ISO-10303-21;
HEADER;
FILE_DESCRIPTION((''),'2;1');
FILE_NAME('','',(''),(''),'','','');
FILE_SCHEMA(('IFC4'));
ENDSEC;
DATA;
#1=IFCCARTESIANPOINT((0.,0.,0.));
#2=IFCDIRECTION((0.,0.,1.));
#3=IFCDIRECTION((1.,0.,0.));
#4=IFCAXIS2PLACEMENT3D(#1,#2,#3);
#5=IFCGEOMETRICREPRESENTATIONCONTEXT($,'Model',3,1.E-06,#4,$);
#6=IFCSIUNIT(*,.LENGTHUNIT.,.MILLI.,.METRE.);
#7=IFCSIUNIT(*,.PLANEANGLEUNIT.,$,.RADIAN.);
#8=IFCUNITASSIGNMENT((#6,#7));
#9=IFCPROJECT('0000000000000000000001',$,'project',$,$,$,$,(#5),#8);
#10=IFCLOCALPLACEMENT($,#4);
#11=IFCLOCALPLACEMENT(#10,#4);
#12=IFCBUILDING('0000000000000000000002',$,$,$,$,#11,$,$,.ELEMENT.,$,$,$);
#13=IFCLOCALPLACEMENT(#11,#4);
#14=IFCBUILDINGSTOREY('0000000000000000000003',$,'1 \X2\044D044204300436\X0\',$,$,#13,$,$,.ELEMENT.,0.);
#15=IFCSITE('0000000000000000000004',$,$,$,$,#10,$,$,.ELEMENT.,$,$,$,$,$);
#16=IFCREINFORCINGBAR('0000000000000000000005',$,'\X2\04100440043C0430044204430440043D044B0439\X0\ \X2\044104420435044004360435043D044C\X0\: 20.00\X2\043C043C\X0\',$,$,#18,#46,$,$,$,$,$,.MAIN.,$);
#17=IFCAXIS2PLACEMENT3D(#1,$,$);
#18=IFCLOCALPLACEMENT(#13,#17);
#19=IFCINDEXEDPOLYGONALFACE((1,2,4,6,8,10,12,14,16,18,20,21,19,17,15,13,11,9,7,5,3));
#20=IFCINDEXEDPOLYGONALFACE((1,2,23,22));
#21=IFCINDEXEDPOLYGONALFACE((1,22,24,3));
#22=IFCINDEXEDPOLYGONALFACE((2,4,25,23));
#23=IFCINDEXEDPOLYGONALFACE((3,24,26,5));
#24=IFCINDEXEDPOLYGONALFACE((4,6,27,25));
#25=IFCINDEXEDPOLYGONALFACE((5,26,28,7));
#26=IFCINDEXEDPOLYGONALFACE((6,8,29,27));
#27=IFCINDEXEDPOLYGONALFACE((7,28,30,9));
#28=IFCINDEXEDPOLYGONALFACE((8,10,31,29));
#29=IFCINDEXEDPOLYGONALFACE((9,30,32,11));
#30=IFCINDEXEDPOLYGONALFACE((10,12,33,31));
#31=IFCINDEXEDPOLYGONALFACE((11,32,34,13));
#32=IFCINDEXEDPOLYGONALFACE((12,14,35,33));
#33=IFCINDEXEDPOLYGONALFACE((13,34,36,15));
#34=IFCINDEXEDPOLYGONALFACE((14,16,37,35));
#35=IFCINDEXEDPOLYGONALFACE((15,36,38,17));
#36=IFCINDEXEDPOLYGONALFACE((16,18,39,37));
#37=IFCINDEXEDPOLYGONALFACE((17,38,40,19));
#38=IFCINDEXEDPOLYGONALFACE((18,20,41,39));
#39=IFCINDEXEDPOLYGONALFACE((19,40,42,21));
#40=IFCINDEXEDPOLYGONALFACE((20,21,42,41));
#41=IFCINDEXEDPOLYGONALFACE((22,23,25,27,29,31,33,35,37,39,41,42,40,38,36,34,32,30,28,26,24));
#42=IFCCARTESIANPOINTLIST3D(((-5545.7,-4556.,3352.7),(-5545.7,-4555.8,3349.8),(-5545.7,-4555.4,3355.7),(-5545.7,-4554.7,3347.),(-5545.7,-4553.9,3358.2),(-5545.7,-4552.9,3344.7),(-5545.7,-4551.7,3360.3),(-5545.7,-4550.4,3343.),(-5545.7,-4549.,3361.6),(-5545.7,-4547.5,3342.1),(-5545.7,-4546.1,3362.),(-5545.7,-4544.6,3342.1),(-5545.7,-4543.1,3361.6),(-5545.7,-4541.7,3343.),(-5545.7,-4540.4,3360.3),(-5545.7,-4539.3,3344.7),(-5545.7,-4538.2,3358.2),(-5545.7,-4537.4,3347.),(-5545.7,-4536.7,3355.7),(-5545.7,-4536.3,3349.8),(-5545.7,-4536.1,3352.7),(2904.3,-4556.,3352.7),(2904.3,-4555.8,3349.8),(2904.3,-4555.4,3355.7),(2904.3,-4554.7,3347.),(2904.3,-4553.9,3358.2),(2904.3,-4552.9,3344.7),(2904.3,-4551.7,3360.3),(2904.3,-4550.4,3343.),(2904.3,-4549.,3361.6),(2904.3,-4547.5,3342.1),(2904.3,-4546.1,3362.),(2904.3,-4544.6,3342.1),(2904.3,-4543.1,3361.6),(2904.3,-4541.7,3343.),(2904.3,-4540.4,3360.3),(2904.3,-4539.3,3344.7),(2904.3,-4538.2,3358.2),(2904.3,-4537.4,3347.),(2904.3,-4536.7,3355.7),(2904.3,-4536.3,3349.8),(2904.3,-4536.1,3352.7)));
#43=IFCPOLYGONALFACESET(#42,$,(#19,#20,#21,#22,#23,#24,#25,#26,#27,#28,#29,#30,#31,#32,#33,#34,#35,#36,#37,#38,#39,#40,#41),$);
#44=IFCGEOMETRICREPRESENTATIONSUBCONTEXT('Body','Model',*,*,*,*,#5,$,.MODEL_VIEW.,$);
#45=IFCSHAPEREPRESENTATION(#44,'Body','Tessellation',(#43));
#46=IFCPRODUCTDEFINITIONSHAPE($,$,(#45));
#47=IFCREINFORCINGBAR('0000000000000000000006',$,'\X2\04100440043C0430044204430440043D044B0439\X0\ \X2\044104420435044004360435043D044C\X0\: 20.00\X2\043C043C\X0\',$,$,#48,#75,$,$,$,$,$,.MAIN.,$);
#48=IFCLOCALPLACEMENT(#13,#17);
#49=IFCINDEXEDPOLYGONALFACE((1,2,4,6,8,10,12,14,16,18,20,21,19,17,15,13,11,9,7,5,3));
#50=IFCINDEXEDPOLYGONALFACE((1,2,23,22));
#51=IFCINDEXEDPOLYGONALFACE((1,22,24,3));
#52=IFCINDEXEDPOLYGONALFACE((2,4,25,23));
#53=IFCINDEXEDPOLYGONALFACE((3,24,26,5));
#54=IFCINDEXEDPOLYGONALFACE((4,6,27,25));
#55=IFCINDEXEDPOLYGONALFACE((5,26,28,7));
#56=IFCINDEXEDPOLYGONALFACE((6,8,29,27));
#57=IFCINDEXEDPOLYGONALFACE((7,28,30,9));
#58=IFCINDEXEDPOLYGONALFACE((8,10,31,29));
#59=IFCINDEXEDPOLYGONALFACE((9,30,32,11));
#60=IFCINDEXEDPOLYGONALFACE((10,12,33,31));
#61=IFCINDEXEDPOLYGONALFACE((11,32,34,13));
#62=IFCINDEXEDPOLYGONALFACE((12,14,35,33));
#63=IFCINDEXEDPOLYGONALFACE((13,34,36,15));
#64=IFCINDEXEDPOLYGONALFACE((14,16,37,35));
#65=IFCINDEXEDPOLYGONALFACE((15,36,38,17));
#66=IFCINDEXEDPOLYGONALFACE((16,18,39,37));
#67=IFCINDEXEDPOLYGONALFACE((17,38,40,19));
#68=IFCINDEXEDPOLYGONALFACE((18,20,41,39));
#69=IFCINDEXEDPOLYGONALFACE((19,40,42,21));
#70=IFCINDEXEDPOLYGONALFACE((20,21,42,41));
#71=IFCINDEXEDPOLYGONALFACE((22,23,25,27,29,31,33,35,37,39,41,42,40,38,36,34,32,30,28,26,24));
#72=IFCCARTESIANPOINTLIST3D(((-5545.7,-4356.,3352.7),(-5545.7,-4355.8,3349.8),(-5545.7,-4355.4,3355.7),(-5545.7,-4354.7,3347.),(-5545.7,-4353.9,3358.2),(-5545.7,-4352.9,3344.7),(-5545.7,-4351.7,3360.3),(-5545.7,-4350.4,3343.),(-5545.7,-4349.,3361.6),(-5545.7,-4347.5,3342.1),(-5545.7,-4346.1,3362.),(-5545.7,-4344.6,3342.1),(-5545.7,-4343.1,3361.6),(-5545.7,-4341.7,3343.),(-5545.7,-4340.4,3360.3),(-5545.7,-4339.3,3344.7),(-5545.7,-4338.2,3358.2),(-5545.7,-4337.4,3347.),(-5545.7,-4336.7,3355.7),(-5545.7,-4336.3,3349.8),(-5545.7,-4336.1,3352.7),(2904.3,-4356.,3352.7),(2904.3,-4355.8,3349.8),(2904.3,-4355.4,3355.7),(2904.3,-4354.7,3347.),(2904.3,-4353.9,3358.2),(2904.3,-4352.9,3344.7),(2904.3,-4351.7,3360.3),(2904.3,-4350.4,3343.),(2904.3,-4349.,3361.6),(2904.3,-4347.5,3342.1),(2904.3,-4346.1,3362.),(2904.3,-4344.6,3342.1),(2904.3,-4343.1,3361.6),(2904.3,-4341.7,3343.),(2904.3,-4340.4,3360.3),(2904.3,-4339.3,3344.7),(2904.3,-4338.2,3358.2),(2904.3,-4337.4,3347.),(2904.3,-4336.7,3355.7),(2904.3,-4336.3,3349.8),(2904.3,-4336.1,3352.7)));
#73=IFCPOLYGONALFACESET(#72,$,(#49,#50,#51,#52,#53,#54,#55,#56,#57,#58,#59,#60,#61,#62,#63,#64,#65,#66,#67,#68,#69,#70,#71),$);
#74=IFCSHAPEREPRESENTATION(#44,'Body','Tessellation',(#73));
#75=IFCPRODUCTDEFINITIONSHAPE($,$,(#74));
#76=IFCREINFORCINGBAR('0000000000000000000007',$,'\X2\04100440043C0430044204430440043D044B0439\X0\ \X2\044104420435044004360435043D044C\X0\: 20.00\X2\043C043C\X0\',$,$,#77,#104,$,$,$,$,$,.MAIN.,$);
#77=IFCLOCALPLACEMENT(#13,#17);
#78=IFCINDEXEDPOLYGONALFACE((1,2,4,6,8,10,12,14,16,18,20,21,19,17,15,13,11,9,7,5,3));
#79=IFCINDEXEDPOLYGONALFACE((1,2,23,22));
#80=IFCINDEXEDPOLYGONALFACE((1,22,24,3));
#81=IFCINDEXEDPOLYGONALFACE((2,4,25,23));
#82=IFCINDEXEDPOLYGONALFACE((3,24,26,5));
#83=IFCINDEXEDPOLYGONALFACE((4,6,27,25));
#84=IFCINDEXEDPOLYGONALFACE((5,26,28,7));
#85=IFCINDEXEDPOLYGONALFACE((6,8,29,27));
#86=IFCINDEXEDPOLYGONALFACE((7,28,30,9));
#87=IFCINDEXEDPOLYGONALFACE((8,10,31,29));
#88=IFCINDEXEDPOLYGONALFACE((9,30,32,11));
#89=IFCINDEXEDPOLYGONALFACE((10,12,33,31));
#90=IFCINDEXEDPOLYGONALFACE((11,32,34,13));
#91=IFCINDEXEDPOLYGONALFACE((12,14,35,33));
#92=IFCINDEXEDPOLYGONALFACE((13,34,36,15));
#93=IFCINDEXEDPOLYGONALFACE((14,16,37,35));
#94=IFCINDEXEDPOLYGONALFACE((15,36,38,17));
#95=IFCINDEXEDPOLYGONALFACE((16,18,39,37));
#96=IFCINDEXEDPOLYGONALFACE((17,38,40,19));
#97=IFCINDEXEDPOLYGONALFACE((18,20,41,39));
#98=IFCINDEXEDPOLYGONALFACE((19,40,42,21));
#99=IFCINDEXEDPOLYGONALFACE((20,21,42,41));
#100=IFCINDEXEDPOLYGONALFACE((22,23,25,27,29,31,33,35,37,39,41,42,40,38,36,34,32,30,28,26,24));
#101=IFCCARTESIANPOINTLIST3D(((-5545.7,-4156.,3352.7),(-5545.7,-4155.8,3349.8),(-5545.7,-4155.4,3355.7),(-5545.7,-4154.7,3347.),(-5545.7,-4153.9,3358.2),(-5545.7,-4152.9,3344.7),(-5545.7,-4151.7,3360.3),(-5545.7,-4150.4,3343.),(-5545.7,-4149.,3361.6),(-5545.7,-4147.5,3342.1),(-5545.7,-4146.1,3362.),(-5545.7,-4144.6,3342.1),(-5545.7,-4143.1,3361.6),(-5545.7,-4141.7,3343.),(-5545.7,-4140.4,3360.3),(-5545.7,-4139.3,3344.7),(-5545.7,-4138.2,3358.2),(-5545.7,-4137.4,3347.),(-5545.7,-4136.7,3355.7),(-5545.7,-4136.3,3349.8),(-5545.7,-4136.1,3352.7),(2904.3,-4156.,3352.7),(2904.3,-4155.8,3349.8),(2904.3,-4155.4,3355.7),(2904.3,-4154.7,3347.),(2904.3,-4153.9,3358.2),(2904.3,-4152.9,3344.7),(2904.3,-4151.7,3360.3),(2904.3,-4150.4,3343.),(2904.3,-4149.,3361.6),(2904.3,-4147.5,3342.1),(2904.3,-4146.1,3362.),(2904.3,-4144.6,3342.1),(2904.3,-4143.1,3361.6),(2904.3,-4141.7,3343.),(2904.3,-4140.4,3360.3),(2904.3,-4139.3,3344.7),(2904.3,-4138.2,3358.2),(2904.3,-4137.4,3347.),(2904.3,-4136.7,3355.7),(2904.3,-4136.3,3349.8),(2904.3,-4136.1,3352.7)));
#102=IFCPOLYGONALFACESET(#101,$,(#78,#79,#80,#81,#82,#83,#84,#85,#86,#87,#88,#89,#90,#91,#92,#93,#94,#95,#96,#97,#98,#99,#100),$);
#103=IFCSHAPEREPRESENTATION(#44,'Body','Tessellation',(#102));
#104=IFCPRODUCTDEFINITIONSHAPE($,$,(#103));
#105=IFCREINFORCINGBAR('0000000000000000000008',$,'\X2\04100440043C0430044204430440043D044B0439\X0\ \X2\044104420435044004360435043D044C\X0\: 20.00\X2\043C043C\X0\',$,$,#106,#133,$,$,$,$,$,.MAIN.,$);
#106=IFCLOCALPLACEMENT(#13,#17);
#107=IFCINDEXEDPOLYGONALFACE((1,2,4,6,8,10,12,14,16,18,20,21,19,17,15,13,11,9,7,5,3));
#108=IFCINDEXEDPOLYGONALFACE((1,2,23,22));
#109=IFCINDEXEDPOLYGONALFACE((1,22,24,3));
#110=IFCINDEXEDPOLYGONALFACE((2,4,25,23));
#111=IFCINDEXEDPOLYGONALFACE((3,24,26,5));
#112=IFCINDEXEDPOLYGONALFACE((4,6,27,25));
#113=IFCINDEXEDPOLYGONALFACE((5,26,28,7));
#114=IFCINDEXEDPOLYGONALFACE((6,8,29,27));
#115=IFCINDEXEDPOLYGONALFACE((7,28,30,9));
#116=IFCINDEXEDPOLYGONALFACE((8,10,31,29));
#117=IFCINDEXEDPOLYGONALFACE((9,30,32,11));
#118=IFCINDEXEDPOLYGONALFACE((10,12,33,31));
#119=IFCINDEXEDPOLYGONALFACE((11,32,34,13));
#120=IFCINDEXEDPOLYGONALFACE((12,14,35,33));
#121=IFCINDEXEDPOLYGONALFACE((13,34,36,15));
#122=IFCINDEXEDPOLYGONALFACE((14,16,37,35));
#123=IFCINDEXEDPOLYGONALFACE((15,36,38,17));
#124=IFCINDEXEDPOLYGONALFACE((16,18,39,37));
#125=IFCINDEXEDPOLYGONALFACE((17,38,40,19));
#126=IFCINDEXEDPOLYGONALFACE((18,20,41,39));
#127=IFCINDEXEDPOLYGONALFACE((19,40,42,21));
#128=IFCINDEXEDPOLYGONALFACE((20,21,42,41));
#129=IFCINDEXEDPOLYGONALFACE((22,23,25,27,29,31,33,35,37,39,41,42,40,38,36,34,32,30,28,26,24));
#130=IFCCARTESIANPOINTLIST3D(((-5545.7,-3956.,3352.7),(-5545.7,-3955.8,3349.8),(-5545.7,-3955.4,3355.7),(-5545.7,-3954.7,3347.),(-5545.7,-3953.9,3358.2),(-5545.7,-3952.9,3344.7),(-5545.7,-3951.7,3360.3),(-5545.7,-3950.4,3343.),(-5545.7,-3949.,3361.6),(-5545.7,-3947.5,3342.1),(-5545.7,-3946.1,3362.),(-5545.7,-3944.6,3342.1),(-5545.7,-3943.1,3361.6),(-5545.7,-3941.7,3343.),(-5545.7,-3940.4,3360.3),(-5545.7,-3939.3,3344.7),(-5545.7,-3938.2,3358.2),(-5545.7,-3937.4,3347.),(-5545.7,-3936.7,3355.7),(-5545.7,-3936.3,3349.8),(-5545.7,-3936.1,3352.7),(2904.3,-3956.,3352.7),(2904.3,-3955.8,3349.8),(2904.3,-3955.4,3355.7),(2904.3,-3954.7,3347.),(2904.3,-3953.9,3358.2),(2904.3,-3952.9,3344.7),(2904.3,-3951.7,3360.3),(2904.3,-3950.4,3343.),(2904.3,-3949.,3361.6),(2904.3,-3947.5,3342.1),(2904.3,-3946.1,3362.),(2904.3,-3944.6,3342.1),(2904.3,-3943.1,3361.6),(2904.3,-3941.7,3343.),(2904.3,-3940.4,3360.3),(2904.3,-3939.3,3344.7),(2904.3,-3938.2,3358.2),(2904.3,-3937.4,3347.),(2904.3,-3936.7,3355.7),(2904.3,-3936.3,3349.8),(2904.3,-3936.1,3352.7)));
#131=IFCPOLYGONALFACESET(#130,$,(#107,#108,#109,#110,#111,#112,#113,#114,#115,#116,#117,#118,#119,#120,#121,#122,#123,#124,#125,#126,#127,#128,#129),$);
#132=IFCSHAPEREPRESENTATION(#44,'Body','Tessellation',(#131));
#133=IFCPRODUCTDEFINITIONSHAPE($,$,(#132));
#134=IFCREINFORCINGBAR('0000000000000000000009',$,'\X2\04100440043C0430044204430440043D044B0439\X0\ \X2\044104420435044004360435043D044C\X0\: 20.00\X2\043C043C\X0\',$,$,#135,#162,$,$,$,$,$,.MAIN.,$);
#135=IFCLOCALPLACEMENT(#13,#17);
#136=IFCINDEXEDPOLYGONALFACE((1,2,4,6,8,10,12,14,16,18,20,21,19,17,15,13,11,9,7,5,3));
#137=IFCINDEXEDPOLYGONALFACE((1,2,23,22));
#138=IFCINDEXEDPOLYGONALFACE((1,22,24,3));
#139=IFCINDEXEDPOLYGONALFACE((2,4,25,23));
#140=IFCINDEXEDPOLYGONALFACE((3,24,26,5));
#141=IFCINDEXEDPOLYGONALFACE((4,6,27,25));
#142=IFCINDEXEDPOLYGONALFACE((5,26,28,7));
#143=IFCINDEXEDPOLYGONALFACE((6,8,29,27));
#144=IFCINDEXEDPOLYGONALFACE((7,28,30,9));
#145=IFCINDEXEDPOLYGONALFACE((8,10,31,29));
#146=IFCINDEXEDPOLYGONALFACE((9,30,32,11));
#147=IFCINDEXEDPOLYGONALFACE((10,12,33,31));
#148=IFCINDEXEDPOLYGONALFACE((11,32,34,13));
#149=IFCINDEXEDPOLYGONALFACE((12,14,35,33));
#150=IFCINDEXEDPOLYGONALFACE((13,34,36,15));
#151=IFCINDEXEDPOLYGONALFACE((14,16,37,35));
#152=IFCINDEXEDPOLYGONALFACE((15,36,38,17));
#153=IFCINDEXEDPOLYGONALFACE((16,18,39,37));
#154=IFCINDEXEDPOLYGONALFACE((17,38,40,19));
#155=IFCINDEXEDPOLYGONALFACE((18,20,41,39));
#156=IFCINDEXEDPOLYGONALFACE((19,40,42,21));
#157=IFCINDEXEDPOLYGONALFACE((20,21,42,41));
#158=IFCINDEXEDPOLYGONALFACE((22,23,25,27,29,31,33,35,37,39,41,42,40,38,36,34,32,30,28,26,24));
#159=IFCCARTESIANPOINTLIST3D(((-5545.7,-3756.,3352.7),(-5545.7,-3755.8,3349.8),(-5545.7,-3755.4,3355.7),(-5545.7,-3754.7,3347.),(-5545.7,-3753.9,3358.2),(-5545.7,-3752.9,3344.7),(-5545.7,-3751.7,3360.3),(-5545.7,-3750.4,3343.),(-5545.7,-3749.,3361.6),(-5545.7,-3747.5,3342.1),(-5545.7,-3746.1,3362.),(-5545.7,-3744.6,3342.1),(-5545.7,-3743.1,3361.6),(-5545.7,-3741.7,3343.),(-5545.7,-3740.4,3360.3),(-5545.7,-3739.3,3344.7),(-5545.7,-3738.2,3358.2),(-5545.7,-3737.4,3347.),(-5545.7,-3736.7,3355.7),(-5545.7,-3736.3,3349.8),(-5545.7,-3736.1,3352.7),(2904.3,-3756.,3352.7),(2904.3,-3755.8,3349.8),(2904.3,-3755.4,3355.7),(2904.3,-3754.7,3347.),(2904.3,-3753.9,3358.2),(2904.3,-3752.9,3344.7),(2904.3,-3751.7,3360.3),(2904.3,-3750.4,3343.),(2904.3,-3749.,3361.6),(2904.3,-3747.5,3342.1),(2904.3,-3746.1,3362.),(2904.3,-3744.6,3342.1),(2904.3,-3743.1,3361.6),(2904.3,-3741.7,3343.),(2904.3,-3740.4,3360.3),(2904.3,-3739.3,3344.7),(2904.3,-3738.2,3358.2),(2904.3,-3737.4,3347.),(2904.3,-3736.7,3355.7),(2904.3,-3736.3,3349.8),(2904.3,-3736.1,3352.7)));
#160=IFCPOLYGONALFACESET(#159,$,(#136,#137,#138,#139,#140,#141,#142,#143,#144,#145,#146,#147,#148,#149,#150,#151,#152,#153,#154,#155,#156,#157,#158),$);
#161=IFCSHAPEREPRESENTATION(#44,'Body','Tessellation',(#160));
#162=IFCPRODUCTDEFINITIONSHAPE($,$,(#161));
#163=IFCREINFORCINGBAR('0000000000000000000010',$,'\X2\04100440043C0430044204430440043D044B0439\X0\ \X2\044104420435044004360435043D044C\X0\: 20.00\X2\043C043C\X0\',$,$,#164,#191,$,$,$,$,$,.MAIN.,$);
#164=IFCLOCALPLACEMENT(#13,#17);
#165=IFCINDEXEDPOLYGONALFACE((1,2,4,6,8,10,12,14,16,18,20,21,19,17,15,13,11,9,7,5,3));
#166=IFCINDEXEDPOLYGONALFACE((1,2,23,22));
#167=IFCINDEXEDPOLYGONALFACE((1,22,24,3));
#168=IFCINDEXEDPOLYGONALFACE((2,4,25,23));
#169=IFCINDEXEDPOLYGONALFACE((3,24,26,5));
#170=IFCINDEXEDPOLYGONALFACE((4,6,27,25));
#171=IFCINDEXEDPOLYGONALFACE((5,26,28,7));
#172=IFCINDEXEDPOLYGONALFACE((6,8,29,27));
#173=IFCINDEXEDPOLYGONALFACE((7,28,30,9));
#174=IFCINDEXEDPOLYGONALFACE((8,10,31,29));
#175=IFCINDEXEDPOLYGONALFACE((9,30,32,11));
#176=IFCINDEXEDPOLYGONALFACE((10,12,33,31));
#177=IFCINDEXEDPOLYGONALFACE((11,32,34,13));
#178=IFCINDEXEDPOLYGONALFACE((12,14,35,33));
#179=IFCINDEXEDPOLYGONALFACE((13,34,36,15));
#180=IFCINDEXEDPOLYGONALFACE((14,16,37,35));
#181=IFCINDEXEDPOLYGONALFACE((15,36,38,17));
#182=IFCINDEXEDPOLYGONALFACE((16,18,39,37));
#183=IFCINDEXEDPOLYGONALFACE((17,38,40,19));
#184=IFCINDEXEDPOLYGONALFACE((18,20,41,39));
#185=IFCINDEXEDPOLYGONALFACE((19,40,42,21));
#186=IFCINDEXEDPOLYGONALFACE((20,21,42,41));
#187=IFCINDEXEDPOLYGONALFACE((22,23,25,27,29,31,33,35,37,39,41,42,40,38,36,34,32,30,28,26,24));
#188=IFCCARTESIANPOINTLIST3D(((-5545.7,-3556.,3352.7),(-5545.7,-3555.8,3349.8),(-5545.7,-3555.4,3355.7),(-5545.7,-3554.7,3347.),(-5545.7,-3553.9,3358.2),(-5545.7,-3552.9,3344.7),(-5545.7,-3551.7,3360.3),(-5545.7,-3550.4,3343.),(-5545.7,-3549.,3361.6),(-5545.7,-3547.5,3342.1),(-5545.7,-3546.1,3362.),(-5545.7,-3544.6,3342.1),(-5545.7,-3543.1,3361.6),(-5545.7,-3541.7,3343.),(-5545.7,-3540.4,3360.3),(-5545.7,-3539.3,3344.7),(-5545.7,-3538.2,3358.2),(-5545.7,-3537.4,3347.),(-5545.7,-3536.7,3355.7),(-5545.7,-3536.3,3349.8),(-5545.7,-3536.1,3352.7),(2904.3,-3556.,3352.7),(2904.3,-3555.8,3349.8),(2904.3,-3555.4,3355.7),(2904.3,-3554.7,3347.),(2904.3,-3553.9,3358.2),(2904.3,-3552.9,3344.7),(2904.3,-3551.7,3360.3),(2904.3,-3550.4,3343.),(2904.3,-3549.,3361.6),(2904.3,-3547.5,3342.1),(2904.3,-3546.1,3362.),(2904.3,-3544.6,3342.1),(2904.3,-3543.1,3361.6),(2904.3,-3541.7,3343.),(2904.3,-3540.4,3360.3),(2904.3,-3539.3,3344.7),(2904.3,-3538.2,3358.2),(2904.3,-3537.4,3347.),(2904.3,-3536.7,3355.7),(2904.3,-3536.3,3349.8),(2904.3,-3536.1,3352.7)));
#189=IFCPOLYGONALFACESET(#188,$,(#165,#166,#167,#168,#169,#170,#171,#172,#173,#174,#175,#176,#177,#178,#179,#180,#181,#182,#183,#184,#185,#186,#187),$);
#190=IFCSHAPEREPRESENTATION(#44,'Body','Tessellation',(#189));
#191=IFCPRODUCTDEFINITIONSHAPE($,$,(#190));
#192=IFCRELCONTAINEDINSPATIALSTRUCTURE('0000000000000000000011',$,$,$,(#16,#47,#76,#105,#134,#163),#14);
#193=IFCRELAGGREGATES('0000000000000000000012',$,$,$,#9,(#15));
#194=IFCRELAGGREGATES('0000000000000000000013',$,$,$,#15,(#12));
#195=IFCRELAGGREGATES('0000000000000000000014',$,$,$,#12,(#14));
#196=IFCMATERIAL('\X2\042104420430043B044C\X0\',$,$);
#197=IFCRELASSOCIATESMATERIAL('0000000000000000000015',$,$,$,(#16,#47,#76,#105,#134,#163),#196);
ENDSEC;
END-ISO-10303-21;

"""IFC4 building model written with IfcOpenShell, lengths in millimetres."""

from ifc_helpers import new_model, entity, si_unit, origin_with_axes, place, context, subcontext, project, spatial, source, transform, mapped, material, element, save


model = new_model("IFC4")

# Units and contexts
model_context = context("Model", 3, precision=1e-06, world=origin_with_axes())
body_context = subcontext(model_context, "Body", "Model", "MODEL_VIEW")
ifc_project = project(units=[si_unit("LENGTHUNIT", "METRE", prefix="MILLI"), si_unit("PLANEANGLEUNIT", "RADIAN")], contexts=[model_context])

# Site, building, storey
site_placement = place(None, origin_with_axes())
site = spatial("IfcSite", under=ifc_project, at=site_placement, CompositionType="ELEMENT")
building_placement = place(site_placement, origin_with_axes())
building = spatial("IfcBuilding", under=site, at=building_placement, CompositionType="ELEMENT")
storey_placement = place(building_placement, origin_with_axes())
storey = spatial("IfcBuildingStorey", under=building, at=storey_placement, Name="1 этаж", CompositionType="ELEMENT", Elevation=0.0)

# Shared definitions
ifc_material_1 = material(Name="Сталь")

# Reinforcing bars
shared_shape_1 = source(origin_with_axes(), body_context, "Body", "AdvancedSweptSolid", [
    entity("IfcSweptDiskSolid", entity("IfcIndexedPolyCurve", entity("IfcCartesianPointList3D", [[0.0, 0.0, 0.0], [8450.0, 0.0, 0.0]]), [entity("IfcLineIndex", [1, 2])]), 10.0),
])
reinforcing_bar_1_placement = place(storey_placement, origin_with_axes())
element("IfcReinforcingBar", 1, at=reinforcing_bar_1_placement, inside=storey, material=ifc_material_1, Name="Арматурный стержень: 20.00мм", PredefinedType="MAIN", context=body_context, shape_type="MappedRepresentation", body=[
    mapped(shared_shape_1, transform((-5545.7, -4546.1, 3352.0), x_axis=(1.0, 0.0, 0.0), y_axis=(0.0, 1.0, 0.0), z_axis=(0.0, 0.0, 1.0), scale=1.0)),
])
reinforcing_bar_2_placement = place(storey_placement, origin_with_axes())
element("IfcReinforcingBar", 2, at=reinforcing_bar_2_placement, inside=storey, material=ifc_material_1, Name="Арматурный стержень: 20.00мм", PredefinedType="MAIN", context=body_context, shape_type="MappedRepresentation", body=[
    mapped(shared_shape_1, transform((-5545.7, -4346.1, 3352.0), x_axis=(1.0, 0.0, 0.0), y_axis=(0.0, 1.0, 0.0), z_axis=(0.0, 0.0, 1.0), scale=1.0)),
])
reinforcing_bar_3_placement = place(storey_placement, origin_with_axes())
element("IfcReinforcingBar", 3, at=reinforcing_bar_3_placement, inside=storey, material=ifc_material_1, Name="Арматурный стержень: 20.00мм", PredefinedType="MAIN", context=body_context, shape_type="MappedRepresentation", body=[
    mapped(shared_shape_1, transform((-5545.7, -4146.1, 3352.0), x_axis=(1.0, 0.0, 0.0), y_axis=(0.0, 1.0, 0.0), z_axis=(0.0, 0.0, 1.0), scale=1.0)),
])
reinforcing_bar_4_placement = place(storey_placement, origin_with_axes())
element("IfcReinforcingBar", 4, at=reinforcing_bar_4_placement, inside=storey, material=ifc_material_1, Name="Арматурный стержень: 20.00мм", PredefinedType="MAIN", context=body_context, shape_type="MappedRepresentation", body=[
    mapped(shared_shape_1, transform((-5545.7, -3946.1, 3352.0), x_axis=(1.0, 0.0, 0.0), y_axis=(0.0, 1.0, 0.0), z_axis=(0.0, 0.0, 1.0), scale=1.0)),
])
reinforcing_bar_5_placement = place(storey_placement, origin_with_axes())
element("IfcReinforcingBar", 5, at=reinforcing_bar_5_placement, inside=storey, material=ifc_material_1, Name="Арматурный стержень: 20.00мм", PredefinedType="MAIN", context=body_context, shape_type="MappedRepresentation", body=[
    mapped(shared_shape_1, transform((-5545.7, -3746.1, 3352.0), x_axis=(1.0, 0.0, 0.0), y_axis=(0.0, 1.0, 0.0), z_axis=(0.0, 0.0, 1.0), scale=1.0)),
])
reinforcing_bar_6_placement = place(storey_placement, origin_with_axes())
element("IfcReinforcingBar", 6, at=reinforcing_bar_6_placement, inside=storey, material=ifc_material_1, Name="Арматурный стержень: 20.00мм", PredefinedType="MAIN", context=body_context, shape_type="MappedRepresentation", body=[
    mapped(shared_shape_1, transform((-5545.7, -3546.1, 3352.0), x_axis=(1.0, 0.0, 0.0), y_axis=(0.0, 1.0, 0.0), z_axis=(0.0, 0.0, 1.0), scale=1.0)),
])

save(model, "model.ifc")
